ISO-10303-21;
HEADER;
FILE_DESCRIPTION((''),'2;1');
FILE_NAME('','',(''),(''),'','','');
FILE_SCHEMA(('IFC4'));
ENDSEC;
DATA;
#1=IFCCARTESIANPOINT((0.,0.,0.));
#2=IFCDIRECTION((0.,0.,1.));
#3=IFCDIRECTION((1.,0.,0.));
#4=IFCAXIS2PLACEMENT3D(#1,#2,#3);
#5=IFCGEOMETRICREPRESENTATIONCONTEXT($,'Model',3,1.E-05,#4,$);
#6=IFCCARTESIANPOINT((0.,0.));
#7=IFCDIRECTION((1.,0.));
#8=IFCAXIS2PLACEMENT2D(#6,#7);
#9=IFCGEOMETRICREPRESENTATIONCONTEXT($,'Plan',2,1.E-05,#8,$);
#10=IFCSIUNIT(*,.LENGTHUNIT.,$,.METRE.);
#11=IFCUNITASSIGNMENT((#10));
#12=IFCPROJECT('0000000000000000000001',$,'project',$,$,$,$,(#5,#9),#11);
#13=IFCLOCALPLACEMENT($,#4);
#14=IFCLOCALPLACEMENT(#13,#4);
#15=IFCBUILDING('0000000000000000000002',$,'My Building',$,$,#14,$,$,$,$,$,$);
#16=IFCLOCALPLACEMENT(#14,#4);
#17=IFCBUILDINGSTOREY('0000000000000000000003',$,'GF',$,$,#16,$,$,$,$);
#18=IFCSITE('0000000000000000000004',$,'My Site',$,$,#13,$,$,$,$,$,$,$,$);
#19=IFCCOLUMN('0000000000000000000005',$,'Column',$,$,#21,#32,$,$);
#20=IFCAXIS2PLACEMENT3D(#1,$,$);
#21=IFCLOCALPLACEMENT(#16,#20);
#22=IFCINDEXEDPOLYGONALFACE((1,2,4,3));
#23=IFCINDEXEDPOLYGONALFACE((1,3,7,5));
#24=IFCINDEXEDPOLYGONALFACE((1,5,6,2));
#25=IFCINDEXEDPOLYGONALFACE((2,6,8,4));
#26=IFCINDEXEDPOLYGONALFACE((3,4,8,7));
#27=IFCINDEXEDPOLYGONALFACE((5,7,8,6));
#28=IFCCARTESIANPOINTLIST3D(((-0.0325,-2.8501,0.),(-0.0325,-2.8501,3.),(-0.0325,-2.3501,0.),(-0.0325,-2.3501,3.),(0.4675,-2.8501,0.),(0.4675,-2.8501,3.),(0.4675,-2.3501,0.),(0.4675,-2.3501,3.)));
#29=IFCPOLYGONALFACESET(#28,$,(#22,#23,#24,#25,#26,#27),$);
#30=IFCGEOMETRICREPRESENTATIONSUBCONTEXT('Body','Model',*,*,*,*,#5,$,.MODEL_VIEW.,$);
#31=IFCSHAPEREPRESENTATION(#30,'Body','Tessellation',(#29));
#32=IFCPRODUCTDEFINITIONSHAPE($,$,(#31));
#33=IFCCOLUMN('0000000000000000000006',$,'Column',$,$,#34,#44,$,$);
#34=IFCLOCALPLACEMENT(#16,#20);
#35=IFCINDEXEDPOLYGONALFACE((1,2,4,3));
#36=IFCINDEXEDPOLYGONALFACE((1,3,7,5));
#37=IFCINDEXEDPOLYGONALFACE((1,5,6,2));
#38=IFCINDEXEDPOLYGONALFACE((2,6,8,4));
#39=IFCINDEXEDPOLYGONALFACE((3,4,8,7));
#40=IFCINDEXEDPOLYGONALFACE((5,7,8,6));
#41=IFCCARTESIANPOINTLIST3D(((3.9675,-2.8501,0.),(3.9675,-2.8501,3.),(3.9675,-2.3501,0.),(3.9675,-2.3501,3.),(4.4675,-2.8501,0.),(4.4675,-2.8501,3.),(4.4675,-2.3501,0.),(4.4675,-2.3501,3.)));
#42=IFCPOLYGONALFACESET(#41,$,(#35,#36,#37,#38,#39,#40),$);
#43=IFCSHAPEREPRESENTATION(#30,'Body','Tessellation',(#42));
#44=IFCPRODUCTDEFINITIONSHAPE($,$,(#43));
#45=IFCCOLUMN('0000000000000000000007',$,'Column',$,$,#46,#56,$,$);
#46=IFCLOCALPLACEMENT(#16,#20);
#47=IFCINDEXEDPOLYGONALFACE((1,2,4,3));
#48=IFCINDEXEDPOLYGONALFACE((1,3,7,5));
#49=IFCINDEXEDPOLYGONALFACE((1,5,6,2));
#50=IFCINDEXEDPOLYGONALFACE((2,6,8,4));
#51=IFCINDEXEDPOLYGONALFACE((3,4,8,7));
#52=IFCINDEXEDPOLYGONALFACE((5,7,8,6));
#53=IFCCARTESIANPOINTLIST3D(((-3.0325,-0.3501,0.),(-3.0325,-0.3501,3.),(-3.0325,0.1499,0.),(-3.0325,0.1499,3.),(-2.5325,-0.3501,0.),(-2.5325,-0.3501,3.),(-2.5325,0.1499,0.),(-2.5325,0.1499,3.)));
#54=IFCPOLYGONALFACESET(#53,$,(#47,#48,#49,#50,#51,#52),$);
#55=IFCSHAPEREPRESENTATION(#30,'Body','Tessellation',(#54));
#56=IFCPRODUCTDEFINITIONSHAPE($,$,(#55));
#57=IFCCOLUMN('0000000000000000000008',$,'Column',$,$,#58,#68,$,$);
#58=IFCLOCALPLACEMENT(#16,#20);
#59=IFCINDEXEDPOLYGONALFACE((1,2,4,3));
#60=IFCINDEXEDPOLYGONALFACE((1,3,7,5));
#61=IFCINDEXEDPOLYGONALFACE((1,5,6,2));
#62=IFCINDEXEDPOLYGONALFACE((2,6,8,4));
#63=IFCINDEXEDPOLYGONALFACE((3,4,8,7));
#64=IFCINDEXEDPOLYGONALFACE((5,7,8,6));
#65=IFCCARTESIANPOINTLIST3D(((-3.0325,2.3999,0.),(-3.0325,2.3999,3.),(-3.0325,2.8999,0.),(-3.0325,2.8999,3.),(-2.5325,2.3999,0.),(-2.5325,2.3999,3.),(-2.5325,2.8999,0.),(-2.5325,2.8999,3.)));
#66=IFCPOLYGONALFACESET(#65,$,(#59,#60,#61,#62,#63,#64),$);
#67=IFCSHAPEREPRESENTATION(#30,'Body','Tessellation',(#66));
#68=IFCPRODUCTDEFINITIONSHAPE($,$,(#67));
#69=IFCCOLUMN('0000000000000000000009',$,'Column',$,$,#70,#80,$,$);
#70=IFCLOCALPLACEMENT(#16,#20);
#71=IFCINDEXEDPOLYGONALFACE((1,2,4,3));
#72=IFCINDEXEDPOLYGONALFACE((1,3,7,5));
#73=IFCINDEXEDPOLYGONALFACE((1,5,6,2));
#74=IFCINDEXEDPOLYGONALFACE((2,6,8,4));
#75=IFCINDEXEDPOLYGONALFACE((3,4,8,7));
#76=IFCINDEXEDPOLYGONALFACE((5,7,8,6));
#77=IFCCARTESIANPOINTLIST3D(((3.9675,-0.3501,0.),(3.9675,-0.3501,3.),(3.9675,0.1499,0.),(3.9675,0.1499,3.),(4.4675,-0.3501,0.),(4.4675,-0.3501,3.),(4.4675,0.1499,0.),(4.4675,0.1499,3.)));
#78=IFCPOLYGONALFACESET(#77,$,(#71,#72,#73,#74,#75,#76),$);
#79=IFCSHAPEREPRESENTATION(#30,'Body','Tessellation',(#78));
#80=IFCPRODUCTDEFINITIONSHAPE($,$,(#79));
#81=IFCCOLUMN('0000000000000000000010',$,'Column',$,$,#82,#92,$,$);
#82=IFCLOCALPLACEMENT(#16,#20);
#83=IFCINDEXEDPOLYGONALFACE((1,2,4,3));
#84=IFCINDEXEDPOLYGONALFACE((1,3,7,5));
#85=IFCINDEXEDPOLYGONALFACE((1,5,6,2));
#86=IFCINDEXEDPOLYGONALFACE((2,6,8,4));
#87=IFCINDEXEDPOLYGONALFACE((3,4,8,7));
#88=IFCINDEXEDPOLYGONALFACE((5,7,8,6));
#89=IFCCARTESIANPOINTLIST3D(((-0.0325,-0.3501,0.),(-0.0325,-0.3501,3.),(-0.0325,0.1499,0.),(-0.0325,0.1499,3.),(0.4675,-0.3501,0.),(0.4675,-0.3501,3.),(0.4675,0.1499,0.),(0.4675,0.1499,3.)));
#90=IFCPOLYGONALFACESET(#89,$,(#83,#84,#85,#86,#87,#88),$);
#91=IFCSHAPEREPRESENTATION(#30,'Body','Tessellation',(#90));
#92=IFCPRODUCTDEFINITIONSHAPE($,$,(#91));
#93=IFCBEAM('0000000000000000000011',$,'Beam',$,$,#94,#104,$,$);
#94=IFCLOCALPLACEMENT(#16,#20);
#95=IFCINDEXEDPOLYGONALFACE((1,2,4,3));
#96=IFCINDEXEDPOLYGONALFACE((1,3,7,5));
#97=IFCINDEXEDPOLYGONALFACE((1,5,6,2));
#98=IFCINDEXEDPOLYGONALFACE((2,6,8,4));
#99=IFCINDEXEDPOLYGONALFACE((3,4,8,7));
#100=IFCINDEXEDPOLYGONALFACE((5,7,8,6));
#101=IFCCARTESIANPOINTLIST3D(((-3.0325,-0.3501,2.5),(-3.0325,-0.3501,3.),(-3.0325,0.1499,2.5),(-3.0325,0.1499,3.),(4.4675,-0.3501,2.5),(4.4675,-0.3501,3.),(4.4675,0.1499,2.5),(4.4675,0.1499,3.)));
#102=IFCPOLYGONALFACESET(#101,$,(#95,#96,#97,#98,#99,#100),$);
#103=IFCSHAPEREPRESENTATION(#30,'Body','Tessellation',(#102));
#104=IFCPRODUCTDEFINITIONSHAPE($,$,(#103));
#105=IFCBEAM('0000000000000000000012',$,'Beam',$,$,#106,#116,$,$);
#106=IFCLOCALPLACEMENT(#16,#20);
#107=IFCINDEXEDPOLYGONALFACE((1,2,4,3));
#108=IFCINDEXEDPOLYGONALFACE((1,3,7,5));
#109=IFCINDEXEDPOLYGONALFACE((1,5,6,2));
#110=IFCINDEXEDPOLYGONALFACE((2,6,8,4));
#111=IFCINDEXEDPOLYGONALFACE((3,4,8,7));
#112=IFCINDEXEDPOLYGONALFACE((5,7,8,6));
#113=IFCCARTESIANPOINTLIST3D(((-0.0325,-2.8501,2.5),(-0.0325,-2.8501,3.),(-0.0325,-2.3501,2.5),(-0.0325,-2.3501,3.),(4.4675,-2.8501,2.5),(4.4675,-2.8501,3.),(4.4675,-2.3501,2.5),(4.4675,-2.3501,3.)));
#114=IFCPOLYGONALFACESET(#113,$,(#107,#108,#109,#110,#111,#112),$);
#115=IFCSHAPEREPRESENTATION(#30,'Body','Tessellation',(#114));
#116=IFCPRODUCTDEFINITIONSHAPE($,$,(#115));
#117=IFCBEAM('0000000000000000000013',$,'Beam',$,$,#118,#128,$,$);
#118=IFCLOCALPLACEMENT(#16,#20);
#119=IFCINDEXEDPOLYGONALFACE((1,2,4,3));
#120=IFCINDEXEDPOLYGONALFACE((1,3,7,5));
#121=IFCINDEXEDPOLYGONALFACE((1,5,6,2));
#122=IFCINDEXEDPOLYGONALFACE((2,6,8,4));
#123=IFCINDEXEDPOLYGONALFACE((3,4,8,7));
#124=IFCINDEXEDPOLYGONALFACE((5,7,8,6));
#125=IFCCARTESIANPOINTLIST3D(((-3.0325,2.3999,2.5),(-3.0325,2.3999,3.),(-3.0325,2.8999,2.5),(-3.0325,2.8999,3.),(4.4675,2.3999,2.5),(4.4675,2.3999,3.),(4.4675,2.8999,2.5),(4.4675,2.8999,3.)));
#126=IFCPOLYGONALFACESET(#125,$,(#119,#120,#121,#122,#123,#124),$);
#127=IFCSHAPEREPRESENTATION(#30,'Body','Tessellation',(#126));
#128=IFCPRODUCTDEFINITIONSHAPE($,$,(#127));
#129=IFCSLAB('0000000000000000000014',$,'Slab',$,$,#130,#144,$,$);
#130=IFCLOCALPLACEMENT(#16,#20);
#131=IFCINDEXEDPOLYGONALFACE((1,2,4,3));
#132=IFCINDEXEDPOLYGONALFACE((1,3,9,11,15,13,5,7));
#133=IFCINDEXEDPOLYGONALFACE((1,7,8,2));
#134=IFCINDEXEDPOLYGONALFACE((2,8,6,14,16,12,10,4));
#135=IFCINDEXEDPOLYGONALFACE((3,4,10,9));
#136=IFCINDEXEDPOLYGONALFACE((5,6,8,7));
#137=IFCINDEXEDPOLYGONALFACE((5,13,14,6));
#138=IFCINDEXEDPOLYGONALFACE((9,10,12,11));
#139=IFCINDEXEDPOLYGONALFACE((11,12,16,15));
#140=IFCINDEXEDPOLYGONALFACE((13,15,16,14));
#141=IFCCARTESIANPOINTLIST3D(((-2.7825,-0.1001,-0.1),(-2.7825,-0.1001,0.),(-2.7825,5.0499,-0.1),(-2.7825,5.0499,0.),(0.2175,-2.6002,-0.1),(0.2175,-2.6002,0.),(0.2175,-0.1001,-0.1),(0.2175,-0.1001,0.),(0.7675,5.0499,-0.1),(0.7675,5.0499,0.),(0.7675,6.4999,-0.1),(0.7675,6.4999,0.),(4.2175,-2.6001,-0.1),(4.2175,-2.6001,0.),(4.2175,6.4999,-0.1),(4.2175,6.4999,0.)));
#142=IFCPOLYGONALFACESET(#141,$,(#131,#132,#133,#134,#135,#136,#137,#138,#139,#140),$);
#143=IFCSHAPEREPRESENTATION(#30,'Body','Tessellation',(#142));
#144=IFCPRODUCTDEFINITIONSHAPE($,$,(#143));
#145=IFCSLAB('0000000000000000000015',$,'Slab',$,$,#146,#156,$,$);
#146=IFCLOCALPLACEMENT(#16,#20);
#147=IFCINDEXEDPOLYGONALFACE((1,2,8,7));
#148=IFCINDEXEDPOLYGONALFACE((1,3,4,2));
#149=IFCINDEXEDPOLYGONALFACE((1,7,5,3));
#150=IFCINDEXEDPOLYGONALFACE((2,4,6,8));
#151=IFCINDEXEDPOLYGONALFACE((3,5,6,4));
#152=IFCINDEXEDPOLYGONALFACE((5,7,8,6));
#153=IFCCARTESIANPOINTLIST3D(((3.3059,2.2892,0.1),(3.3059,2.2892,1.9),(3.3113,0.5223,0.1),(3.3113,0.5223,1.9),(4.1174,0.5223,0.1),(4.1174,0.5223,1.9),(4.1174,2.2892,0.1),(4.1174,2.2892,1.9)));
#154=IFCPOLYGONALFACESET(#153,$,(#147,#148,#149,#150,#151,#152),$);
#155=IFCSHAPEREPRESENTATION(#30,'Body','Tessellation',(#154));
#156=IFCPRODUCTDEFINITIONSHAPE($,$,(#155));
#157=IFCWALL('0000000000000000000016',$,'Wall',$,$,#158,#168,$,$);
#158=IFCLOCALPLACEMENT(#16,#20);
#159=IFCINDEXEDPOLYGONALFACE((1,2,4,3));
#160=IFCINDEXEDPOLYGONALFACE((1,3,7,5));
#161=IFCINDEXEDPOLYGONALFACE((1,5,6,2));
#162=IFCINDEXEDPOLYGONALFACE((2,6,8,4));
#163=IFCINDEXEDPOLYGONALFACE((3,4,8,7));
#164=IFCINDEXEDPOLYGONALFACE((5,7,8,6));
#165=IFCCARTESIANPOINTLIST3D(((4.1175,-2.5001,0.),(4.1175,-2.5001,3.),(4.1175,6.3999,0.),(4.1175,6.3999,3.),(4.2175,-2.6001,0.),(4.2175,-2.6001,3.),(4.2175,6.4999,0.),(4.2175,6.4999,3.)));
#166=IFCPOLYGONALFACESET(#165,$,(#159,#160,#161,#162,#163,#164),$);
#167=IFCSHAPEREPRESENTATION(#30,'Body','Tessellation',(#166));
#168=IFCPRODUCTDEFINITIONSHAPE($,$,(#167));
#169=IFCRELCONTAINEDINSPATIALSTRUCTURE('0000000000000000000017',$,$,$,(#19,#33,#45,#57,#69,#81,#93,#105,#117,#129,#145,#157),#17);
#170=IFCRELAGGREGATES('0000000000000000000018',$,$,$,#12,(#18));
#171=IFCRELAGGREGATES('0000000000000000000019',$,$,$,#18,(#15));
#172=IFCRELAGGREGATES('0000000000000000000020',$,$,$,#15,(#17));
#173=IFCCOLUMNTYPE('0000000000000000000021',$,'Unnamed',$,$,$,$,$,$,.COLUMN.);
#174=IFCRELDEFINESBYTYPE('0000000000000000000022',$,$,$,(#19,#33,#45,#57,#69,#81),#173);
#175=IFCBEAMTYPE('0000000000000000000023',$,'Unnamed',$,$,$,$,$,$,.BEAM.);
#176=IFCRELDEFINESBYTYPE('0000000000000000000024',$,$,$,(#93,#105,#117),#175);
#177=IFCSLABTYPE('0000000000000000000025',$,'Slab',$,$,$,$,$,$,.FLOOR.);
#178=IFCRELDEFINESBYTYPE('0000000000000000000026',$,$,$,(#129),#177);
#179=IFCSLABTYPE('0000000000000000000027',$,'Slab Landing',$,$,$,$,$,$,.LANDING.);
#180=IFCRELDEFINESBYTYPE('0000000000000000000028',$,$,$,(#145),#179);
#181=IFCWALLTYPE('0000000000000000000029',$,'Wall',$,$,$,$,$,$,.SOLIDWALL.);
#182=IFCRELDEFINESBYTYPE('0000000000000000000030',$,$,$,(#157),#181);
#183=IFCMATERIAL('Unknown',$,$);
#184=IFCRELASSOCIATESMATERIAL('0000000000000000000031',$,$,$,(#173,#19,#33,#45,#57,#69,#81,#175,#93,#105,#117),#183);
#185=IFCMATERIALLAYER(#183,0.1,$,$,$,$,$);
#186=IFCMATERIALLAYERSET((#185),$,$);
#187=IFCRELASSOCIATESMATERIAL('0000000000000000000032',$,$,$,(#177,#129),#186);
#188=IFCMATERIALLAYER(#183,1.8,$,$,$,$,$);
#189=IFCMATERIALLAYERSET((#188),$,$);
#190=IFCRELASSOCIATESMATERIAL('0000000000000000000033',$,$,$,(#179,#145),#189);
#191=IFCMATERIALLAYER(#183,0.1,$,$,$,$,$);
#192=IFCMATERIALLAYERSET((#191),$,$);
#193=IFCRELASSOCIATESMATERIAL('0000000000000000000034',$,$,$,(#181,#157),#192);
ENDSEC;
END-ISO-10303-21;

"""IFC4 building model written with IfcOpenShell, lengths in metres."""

from ifc_helpers import new_model, si_unit, frame, origin_with_axes, origin_2d_with_axis, place, context, subcontext, project, spatial, line, indexed_curve, rectangle, outline, extrude, material, layer, layer_set, layer_usage, material_profile, profile_set, profile_usage, type_object, element, save


model = new_model("IFC4")

# Units and contexts
model_context = context("Model", 3, precision=1e-05, world=origin_with_axes())
plan_context = context("Plan", 2, precision=1e-05, world=origin_2d_with_axis())
body_context_1 = subcontext(model_context, "Body", "Model", "MODEL_VIEW")
ifc_project = project(units=[si_unit("LENGTHUNIT", "METRE")], contexts=[model_context, plan_context])

# Site, building, storey
site_placement = place(None, origin_with_axes())
site = spatial("IfcSite", under=ifc_project, at=site_placement, Name="My Site")
building_placement = place(site_placement, origin_with_axes())
building = spatial("IfcBuilding", under=site, at=building_placement, Name="My Building")
storey_placement = place(building_placement, origin_with_axes())
storey = spatial("IfcBuildingStorey", under=building, at=storey_placement, Name="GF")

# Columns
ifc_material = material(Name="Unknown")
ifc_material_profile_1 = material_profile(ifc_material, rectangle(XDim=0.5, YDim=0.5))
ifc_profile_set_1 = profile_set([ifc_material_profile_1])
ifc_profile_usage_1 = profile_usage(ifc_profile_set_1, cardinal=5)
column_type = type_object("IfcColumnType", Name="Unnamed", PredefinedType="COLUMN", material=ifc_profile_set_1)
column_1_placement = place(storey_placement, frame((0.2175, -2.6001, 0.0), z_axis=(0.0, 0.0, 1.0), x_axis=(1.0, 0.0, 0.0)))
element("IfcColumn", 1, at=column_1_placement, inside=storey, type_object=column_type, material=ifc_profile_usage_1, Name="Column", context=body_context_1, shape_type="SweptSolid", body=[
    extrude(rectangle(XDim=0.5, YDim=0.5), origin_with_axes(), (0.0, 0.0, 1.0), 3.0),
])
ifc_profile_usage_2 = profile_usage(ifc_profile_set_1, cardinal=5)
column_2_placement = place(storey_placement, frame((4.2175, -2.6001, 0.0), z_axis=(0.0, 0.0, 1.0), x_axis=(1.0, 0.0, 0.0)))
element("IfcColumn", 2, at=column_2_placement, inside=storey, type_object=column_type, material=ifc_profile_usage_2, Name="Column", context=body_context_1, shape_type="SweptSolid", body=[
    extrude(rectangle(XDim=0.5, YDim=0.5), origin_with_axes(), (0.0, 0.0, 1.0), 3.0),
])
ifc_profile_usage_3 = profile_usage(ifc_profile_set_1, cardinal=5)
column_3_placement = place(storey_placement, frame((-2.7825, -0.1001, 0.0), z_axis=(0.0, 0.0, 1.0), x_axis=(1.0, 0.0, 0.0)))
element("IfcColumn", 3, at=column_3_placement, inside=storey, type_object=column_type, material=ifc_profile_usage_3, Name="Column", context=body_context_1, shape_type="SweptSolid", body=[
    extrude(rectangle(XDim=0.5, YDim=0.5), origin_with_axes(), (0.0, 0.0, 1.0), 3.0),
])
ifc_profile_usage_4 = profile_usage(ifc_profile_set_1, cardinal=5)
column_4_placement = place(storey_placement, frame((-2.7825, 2.6499, 0.0), z_axis=(0.0, 0.0, 1.0), x_axis=(1.0, 0.0, 0.0)))
element("IfcColumn", 4, at=column_4_placement, inside=storey, type_object=column_type, material=ifc_profile_usage_4, Name="Column", context=body_context_1, shape_type="SweptSolid", body=[
    extrude(rectangle(XDim=0.5, YDim=0.5), origin_with_axes(), (0.0, 0.0, 1.0), 3.0),
])
ifc_profile_usage_5 = profile_usage(ifc_profile_set_1, cardinal=5)
column_5_placement = place(storey_placement, frame((4.2175, -0.1001, 0.0), z_axis=(0.0, 0.0, 1.0), x_axis=(1.0, 0.0, 0.0)))
element("IfcColumn", 5, at=column_5_placement, inside=storey, type_object=column_type, material=ifc_profile_usage_5, Name="Column", context=body_context_1, shape_type="SweptSolid", body=[
    extrude(rectangle(XDim=0.5, YDim=0.5), origin_with_axes(), (0.0, 0.0, 1.0), 3.0),
])
ifc_profile_usage_6 = profile_usage(ifc_profile_set_1, cardinal=5)
column_6_placement = place(storey_placement, frame((0.2175, -0.1001, 0.0), z_axis=(0.0, 0.0, 1.0), x_axis=(1.0, 0.0, 0.0)))
element("IfcColumn", 6, at=column_6_placement, inside=storey, type_object=column_type, material=ifc_profile_usage_6, Name="Column", context=body_context_1, shape_type="SweptSolid", body=[
    extrude(rectangle(XDim=0.5, YDim=0.5), origin_with_axes(), (0.0, 0.0, 1.0), 3.0),
])

# Beams
ifc_material_profile_2 = material_profile(ifc_material, rectangle(XDim=0.5, YDim=0.5))
ifc_profile_set_2 = profile_set([ifc_material_profile_2])
ifc_profile_usage_7 = profile_usage(ifc_profile_set_2, cardinal=7)
beam_type = type_object("IfcBeamType", Name="Unnamed", PredefinedType="BEAM", material=ifc_profile_set_2)
beam_1_placement = place(storey_placement, frame((4.4675, -0.3501, 3.0), z_axis=(-1.0, 0.0, 0.0), x_axis=(0.0, -1.0, 0.0)))
element("IfcBeam", 7, at=beam_1_placement, inside=storey, type_object=beam_type, material=ifc_profile_usage_7, Name="Beam", context=body_context_1, shape_type="SweptSolid", body=[
    extrude(rectangle(XDim=0.5, YDim=0.5), frame((-0.25, -0.25, 0.0), z_axis=(0.0, 0.0, 1.0), x_axis=(1.0, 0.0, 0.0)), (0.0, 0.0, 1.0), 7.5),
])
ifc_profile_usage_8 = profile_usage(ifc_profile_set_2, cardinal=7)
beam_2_placement = place(storey_placement, frame((4.4675, -2.8501, 3.0), z_axis=(-1.0, 0.0, 0.0), x_axis=(0.0, -1.0, 0.0)))
element("IfcBeam", 8, at=beam_2_placement, inside=storey, type_object=beam_type, material=ifc_profile_usage_8, Name="Beam", context=body_context_1, shape_type="SweptSolid", body=[
    extrude(rectangle(XDim=0.5, YDim=0.5), frame((-0.25, -0.25, 0.0), z_axis=(0.0, 0.0, 1.0), x_axis=(1.0, 0.0, 0.0)), (0.0, 0.0, 1.0), 4.5),
])
ifc_profile_usage_9 = profile_usage(ifc_profile_set_2, cardinal=7)
beam_3_placement = place(storey_placement, frame((4.4675, 2.3999, 3.0), z_axis=(-1.0, 0.0, 0.0), x_axis=(0.0, -1.0, 0.0)))
element("IfcBeam", 9, at=beam_3_placement, inside=storey, type_object=beam_type, material=ifc_profile_usage_9, Name="Beam", context=body_context_1, shape_type="SweptSolid", body=[
    extrude(rectangle(XDim=0.5, YDim=0.5), frame((-0.25, -0.25, 0.0), z_axis=(0.0, 0.0, 1.0), x_axis=(1.0, 0.0, 0.0)), (0.0, 0.0, 1.0), 7.5),
])

# Slabs
ifc_layer_1 = layer(ifc_material, 0.1)
ifc_layer_set_1 = layer_set([ifc_layer_1])
ifc_layer_usage_1 = layer_usage(ifc_layer_set_1, "AXIS3", "POSITIVE", -0.1)
slab_type_1 = type_object("IfcSlabType", Name="Slab", PredefinedType="FLOOR", material=ifc_layer_set_1)
slab_1_placement = place(storey_placement, frame((4.2175, -2.6001, 0.0), z_axis=(0.0, 0.0, 1.0), x_axis=(1.0, 0.0, 0.0)))
element("IfcSlab", 10, at=slab_1_placement, inside=storey, type_object=slab_type_1, material=ifc_layer_usage_1, Name="Slab", context=body_context_1, shape_type="SweptSolid", body=[
    extrude(outline(indexed_curve([(0.0, 0.0), (0.0, 9.1), (-3.45, 9.1), (-3.45, 7.6499), (-7.0, 7.6499), (-7.0, 2.5), (-4.0, 2.5), (-4.0, -0.0001), (0.0, 0.0)])), frame((0.0, 0.0, -0.1), z_axis=(0.0, 0.0, 1.0), x_axis=(1.0, 0.0, 0.0)), (0.0, 0.0, 1.0), 0.1),
])
ifc_layer_2 = layer(ifc_material, 1.8)
ifc_layer_set_2 = layer_set([ifc_layer_2])
ifc_layer_usage_2 = layer_usage(ifc_layer_set_2, "AXIS3", "POSITIVE", -1.8)
slab_type_2 = type_object("IfcSlabType", Name="Slab Landing", PredefinedType="LANDING", material=ifc_layer_set_2)
slab_2_placement = place(storey_placement, frame((3.3113, 0.5223, 1.9), z_axis=(0.0, 0.0, 1.0), x_axis=(1.0, 0.0, 0.0)))
element("IfcSlab", 11, at=slab_2_placement, inside=storey, type_object=slab_type_2, material=ifc_layer_usage_2, Name="Slab", context=body_context_1, shape_type="SweptSolid", body=[
    extrude(outline(indexed_curve([(0.0, 0.0), (0.8061, 0.0), (0.8061, 1.767), (-0.0054, 1.767), (0.0, 0.0)])), frame((0.0, 0.0, -1.8), z_axis=(0.0, 0.0, 1.0), x_axis=(1.0, 0.0, 0.0)), (0.0, 0.0, 1.0), 1.8),
])

# Shared definitions
ifc_layer_3 = layer(ifc_material, 0.1)
ifc_layer_set_3 = layer_set([ifc_layer_3])
wall_type = type_object("IfcWallType", Name="Wall", PredefinedType="SOLIDWALL", material=ifc_layer_set_3)

# Wall
ifc_layer_usage_3 = layer_usage(ifc_layer_set_3, "AXIS2", "POSITIVE", 0.0)
wall_1_placement = place(storey_placement, frame((4.2175, -2.6001, 0.0), z_axis=(0.0, 0.0, 1.0), x_axis=(0.0, 1.0, 0.0)))
element("IfcWall", 12, at=wall_1_placement, inside=storey, type_object=wall_type, material=ifc_layer_usage_3, Name="Wall", context=body_context_1, shape_type="SweptSolid", body=[
    extrude(outline(indexed_curve([(0.0, 0.0), (0.1, 0.1), (9.0, 0.1), (9.1, 0.0)], segments=[line(1, 2, 3, 4, 1)])), origin_with_axes(), (0.0, 0.0, 1.0), 3.0),
])

save(model, "model.ifc")
